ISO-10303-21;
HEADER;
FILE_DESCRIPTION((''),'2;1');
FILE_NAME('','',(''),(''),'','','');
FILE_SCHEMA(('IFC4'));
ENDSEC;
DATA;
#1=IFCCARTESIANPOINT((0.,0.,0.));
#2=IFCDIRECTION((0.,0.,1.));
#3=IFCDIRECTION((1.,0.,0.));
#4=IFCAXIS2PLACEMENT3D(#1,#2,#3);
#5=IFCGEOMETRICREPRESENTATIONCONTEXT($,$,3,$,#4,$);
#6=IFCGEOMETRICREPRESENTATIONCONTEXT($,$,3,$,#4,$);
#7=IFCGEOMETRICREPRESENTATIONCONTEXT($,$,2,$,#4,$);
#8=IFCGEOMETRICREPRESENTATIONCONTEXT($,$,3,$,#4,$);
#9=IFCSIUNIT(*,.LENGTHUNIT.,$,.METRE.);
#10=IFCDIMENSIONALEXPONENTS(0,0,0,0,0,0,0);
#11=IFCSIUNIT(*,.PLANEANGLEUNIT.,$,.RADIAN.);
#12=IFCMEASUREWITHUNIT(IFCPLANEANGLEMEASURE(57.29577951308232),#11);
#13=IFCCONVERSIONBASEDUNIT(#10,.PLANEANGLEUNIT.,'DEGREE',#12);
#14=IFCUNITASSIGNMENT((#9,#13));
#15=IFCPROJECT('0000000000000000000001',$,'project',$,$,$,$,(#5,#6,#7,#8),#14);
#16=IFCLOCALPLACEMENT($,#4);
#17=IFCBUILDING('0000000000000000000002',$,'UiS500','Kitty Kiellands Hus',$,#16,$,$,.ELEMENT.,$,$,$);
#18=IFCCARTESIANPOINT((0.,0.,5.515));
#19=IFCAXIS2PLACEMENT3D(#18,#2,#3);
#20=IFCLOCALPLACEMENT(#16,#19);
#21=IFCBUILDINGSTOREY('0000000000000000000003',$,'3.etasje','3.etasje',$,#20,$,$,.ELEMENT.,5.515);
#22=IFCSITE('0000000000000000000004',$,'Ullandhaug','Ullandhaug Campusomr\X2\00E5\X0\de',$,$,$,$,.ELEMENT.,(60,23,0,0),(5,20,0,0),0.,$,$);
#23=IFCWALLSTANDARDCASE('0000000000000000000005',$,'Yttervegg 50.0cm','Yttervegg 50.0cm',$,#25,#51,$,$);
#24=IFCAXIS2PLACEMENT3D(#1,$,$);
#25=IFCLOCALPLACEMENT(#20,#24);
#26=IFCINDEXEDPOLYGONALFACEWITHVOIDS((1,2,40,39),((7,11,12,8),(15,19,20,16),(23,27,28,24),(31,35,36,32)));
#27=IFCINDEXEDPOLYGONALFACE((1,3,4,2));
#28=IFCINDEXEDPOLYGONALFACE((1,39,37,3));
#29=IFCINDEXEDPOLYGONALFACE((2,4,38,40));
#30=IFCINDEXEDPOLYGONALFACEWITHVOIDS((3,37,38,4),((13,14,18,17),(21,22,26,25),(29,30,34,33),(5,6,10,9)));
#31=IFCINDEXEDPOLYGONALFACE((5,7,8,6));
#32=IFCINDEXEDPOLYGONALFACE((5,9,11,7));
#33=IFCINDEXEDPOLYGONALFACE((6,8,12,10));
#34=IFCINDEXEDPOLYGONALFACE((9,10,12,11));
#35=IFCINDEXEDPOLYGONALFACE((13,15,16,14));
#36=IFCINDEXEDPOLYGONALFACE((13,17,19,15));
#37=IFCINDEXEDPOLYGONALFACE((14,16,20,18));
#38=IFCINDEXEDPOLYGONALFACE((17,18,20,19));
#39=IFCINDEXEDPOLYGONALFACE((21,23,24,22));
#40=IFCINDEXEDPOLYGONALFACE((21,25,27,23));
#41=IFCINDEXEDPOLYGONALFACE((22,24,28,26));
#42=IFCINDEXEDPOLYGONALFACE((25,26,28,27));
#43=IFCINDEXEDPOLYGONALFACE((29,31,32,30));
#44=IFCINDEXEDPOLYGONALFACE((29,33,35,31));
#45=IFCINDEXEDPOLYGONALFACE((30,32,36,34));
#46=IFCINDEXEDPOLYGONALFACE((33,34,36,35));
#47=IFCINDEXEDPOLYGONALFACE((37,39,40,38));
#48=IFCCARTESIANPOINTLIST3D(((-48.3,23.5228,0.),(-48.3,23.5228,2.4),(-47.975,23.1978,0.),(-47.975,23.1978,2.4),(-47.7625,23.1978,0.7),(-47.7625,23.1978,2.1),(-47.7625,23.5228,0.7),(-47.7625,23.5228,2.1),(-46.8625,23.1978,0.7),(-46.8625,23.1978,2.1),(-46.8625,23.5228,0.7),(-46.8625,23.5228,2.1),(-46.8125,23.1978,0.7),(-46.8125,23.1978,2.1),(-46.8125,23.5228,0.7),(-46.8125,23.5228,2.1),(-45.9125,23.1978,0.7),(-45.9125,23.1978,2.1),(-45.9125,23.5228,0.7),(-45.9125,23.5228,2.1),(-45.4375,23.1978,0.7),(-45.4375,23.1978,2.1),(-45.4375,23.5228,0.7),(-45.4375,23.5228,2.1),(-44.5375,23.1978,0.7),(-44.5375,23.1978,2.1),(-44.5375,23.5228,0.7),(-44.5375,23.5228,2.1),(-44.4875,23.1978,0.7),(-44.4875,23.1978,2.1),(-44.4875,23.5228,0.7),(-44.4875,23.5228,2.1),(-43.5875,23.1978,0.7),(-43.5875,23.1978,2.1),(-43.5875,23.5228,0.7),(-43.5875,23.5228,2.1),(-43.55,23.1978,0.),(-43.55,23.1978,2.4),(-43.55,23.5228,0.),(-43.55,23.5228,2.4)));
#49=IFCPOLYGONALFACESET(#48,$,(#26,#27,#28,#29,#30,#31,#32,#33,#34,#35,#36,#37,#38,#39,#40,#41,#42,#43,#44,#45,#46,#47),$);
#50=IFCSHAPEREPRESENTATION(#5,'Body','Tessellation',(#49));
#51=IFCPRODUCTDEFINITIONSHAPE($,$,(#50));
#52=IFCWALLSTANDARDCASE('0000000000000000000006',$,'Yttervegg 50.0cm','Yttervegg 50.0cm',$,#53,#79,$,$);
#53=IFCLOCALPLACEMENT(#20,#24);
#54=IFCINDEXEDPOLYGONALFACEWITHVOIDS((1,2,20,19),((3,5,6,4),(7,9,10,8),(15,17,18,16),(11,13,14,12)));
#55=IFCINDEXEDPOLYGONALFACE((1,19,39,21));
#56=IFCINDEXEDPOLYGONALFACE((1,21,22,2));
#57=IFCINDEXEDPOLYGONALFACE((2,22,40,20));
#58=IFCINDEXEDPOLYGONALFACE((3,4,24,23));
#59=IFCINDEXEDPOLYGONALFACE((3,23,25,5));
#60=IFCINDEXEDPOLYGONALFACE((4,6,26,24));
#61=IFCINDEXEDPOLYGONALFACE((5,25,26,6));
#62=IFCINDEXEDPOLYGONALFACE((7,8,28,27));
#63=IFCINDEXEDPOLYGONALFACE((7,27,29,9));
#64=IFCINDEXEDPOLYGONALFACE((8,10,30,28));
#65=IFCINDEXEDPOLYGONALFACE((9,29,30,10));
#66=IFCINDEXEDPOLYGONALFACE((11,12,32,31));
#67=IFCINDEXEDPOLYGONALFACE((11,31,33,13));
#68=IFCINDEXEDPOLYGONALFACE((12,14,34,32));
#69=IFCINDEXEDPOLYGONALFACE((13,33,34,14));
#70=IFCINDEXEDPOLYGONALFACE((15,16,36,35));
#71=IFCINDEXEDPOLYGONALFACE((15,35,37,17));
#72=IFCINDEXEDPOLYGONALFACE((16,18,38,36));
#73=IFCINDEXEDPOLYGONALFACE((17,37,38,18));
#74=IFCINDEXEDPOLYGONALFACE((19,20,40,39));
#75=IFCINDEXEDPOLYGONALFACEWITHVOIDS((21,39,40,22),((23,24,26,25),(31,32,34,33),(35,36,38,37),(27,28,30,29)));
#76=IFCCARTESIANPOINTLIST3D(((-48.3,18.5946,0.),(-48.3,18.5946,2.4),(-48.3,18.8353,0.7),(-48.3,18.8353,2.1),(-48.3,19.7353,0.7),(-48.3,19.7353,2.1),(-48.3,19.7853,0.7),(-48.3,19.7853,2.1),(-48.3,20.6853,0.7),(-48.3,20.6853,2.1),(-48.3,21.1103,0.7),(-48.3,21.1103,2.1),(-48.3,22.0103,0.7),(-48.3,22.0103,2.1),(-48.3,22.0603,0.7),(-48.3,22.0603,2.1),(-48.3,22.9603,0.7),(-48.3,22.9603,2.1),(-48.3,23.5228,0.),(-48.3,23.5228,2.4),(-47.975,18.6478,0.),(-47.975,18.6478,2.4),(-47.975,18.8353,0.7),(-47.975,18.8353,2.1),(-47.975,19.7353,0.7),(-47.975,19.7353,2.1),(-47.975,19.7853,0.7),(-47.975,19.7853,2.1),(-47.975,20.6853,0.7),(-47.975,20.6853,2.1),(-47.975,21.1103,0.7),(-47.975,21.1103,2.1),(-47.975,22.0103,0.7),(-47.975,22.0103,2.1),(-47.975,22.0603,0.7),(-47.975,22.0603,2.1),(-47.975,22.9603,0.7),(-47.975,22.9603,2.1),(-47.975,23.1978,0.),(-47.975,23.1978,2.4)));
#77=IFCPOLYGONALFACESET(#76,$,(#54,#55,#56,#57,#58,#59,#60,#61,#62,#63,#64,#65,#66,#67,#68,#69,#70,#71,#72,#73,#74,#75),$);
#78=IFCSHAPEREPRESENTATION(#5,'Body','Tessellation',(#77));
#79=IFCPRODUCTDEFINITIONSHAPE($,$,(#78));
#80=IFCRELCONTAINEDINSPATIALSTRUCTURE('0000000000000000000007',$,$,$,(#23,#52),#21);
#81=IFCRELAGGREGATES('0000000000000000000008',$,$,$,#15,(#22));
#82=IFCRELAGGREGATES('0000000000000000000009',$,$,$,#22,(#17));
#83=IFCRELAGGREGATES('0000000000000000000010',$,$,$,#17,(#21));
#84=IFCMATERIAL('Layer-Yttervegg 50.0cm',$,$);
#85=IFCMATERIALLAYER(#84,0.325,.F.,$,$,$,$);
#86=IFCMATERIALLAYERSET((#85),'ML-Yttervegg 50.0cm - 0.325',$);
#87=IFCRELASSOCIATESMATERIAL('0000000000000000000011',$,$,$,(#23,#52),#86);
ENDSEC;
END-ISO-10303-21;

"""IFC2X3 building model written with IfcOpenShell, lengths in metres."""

from ifc_helpers import new_model, entity, si_unit, converted_unit, frame, origin_with_axes, place, context, project, spatial, polyline, outline, extrude, material, layer, layer_set, layer_usage, element, save


model = new_model("IFC2X3")

# Units and contexts
context_of_model_1 = context(None, 3, world=origin_with_axes())
context_of_model_2 = context(None, 3, world=origin_with_axes())
context_of_model_3 = context(None, 2, world=origin_with_axes())
context_of_model_4 = context(None, 3, world=origin_with_axes())
ifc_project = project(units=[si_unit("LENGTHUNIT", "METRE"), converted_unit("PLANEANGLEUNIT", "DEGREE", entity("IfcPlaneAngleMeasure", 57.29577951308232), si_unit("PLANEANGLEUNIT", "RADIAN"), dimensions=[0, 0, 0, 0, 0, 0, 0])], contexts=[context_of_model_1, context_of_model_2, context_of_model_3, context_of_model_4])

# Site, building, storey
site = spatial("IfcSite", under=ifc_project, Name="Ullandhaug", Description="Ullandhaug Campusområde", CompositionType="ELEMENT", RefLatitude=(60, 23, 0, 0), RefLongitude=(5, 20, 0, 0), RefElevation=0.0)
building_placement = place(None, origin_with_axes())
building = spatial("IfcBuilding", under=site, at=building_placement, Name="UiS500", Description="Kitty Kiellands Hus", CompositionType="ELEMENT")
storey_placement = place(building_placement, frame((0.0, 0.0, 5.515), z_axis=(0.0, 0.0, 1.0), x_axis=(1.0, 0.0, 0.0)))
storey = spatial("IfcBuildingStorey", under=building, at=storey_placement, Name="3.etasje", Description="3.etasje", CompositionType="ELEMENT", Elevation=5.515)

# Shared definitions
ifc_material_1 = material(Name="Layer-Yttervegg 50.0cm")
ifc_layer_1 = layer(ifc_material_1, 0.325, ventilated=False)
ifc_layer_set_1 = layer_set([ifc_layer_1], Name="ML-Yttervegg 50.0cm - 0.325")
ifc_layer_usage_1 = layer_usage(ifc_layer_set_1, "AXIS2", "POSITIVE", 0.0)

# Walls, openings
wall_1_placement = place(storey_placement, frame((-43.55, 23.5228, 0.0), z_axis=(0.0, 0.0, 1.0), x_axis=(-1.0, 0.0, 0.0)))
wall_1 = element("IfcWallStandardCase", 1, at=wall_1_placement, inside=storey, material=ifc_layer_usage_1, Name="Yttervegg 50.0cm", Description="Yttervegg 50.0cm", context=context_of_model_1, shape_type="SweptSolid", body=[
    extrude(outline(polyline([(0.0, 0.0), (4.75, 0.0), (4.425, 0.325), (0.0, 0.325), (0.0, 0.0)])), frame((0.0, 0.0, 0.0), z_axis=(0.0, 0.0, 1.0), x_axis=(1.0, 0.0, 0.0)), (0.0, 0.0, 1.0), 2.4),
])
opening_1_placement = place(wall_1_placement, frame((0.0375, 0.325, 0.7), z_axis=(0.0, 0.0, 1.0), x_axis=(1.0, 0.0, 0.0)))
element("IfcOpeningElement", 2, at=opening_1_placement, cuts=wall_1, context=context_of_model_1, shape_type="SweptSolid", body=[
    extrude(outline(polyline([(0.0, 0.0), (1.4, 0.0), (1.4, 0.9), (0.0, 0.9), (0.0, 0.0)])), frame((0.0, 0.0, 0.0), z_axis=(0.0, 1.0, 0.0), x_axis=(0.0, 0.0, 1.0)), (0.0, 0.0, -1.0), 0.325),
])
opening_2_placement = place(wall_1_placement, frame((0.9875, 0.325, 0.7), z_axis=(0.0, 0.0, 1.0), x_axis=(1.0, 0.0, 0.0)))
element("IfcOpeningElement", 3, at=opening_2_placement, cuts=wall_1, context=context_of_model_1, shape_type="SweptSolid", body=[
    extrude(outline(polyline([(0.0, 0.0), (1.4, 0.0), (1.4, 0.9), (0.0, 0.9), (0.0, 0.0)])), frame((0.0, 0.0, 0.0), z_axis=(0.0, 1.0, 0.0), x_axis=(0.0, 0.0, 1.0)), (0.0, 0.0, -1.0), 0.325),
])
opening_3_placement = place(wall_1_placement, frame((2.3625, 0.325, 0.7), z_axis=(0.0, 0.0, 1.0), x_axis=(1.0, 0.0, 0.0)))
element("IfcOpeningElement", 4, at=opening_3_placement, cuts=wall_1, context=context_of_model_1, shape_type="SweptSolid", body=[
    extrude(outline(polyline([(0.0, 0.0), (1.4, 0.0), (1.4, 0.9), (0.0, 0.9), (0.0, 0.0)])), frame((0.0, 0.0, 0.0), z_axis=(0.0, 1.0, 0.0), x_axis=(0.0, 0.0, 1.0)), (0.0, 0.0, -1.0), 0.325),
])
opening_4_placement = place(wall_1_placement, frame((3.3125, 0.325, 0.7), z_axis=(0.0, 0.0, 1.0), x_axis=(1.0, 0.0, 0.0)))
element("IfcOpeningElement", 5, at=opening_4_placement, cuts=wall_1, context=context_of_model_1, shape_type="SweptSolid", body=[
    extrude(outline(polyline([(0.0, 0.0), (1.4, 0.0), (1.4, 0.9), (0.0, 0.9), (0.0, 0.0)])), frame((0.0, 0.0, 0.0), z_axis=(0.0, 1.0, 0.0), x_axis=(0.0, 0.0, 1.0)), (0.0, 0.0, -1.0), 0.325),
])
wall_2_placement = place(storey_placement, frame((-48.3, 23.5228, 0.0), z_axis=(0.0, 0.0, 1.0), x_axis=(0.0, -1.0, 0.0)))
wall_2 = element("IfcWallStandardCase", 6, at=wall_2_placement, inside=storey, material=ifc_layer_usage_1, Name="Yttervegg 50.0cm", Description="Yttervegg 50.0cm", context=context_of_model_1, shape_type="SweptSolid", body=[
    extrude(outline(polyline([(0.0, 0.0), (4.9281, 0.0), (4.875, 0.325), (0.325, 0.325), (0.0, 0.0)])), frame((0.0, 0.0, 0.0), z_axis=(0.0, 0.0, 1.0), x_axis=(1.0, 0.0, 0.0)), (0.0, 0.0, 1.0), 2.4),
])
opening_5_placement = place(wall_2_placement, frame((0.5625, 0.325, 0.7), z_axis=(0.0, 0.0, 1.0), x_axis=(1.0, 0.0, 0.0)))
element("IfcOpeningElement", 7, at=opening_5_placement, cuts=wall_2, context=context_of_model_1, shape_type="SweptSolid", body=[
    extrude(outline(polyline([(0.0, 0.0), (1.4, 0.0), (1.4, 0.9), (0.0, 0.9), (0.0, 0.0)])), frame((0.0, 0.0, 0.0), z_axis=(0.0, 1.0, 0.0), x_axis=(0.0, 0.0, 1.0)), (0.0, 0.0, -1.0), 0.325),
])
opening_6_placement = place(wall_2_placement, frame((1.5125, 0.325, 0.7), z_axis=(0.0, 0.0, 1.0), x_axis=(1.0, 0.0, 0.0)))
element("IfcOpeningElement", 8, at=opening_6_placement, cuts=wall_2, context=context_of_model_1, shape_type="SweptSolid", body=[
    extrude(outline(polyline([(0.0, 0.0), (1.4, 0.0), (1.4, 0.9), (0.0, 0.9), (0.0, 0.0)])), frame((0.0, 0.0, 0.0), z_axis=(0.0, 1.0, 0.0), x_axis=(0.0, 0.0, 1.0)), (0.0, 0.0, -1.0), 0.325),
])
opening_7_placement = place(wall_2_placement, frame((2.8375, 0.325, 0.7), z_axis=(0.0, 0.0, 1.0), x_axis=(1.0, 0.0, 0.0)))
element("IfcOpeningElement", 9, at=opening_7_placement, cuts=wall_2, context=context_of_model_1, shape_type="SweptSolid", body=[
    extrude(outline(polyline([(0.0, 0.0), (1.4, 0.0), (1.4, 0.9), (0.0, 0.9), (0.0, 0.0)])), frame((0.0, 0.0, 0.0), z_axis=(0.0, 1.0, 0.0), x_axis=(0.0, 0.0, 1.0)), (0.0, 0.0, -1.0), 0.325),
])
opening_8_placement = place(wall_2_placement, frame((3.7875, 0.325, 0.7), z_axis=(0.0, 0.0, 1.0), x_axis=(1.0, 0.0, 0.0)))
element("IfcOpeningElement", 10, at=opening_8_placement, cuts=wall_2, context=context_of_model_1, shape_type="SweptSolid", body=[
    extrude(outline(polyline([(0.0, 0.0), (1.4, 0.0), (1.4, 0.9), (0.0, 0.9), (0.0, 0.0)])), frame((0.0, 0.0, 0.0), z_axis=(0.0, 1.0, 0.0), x_axis=(0.0, 0.0, 1.0)), (0.0, 0.0, -1.0), 0.325),
])

save(model, "model.ifc")
